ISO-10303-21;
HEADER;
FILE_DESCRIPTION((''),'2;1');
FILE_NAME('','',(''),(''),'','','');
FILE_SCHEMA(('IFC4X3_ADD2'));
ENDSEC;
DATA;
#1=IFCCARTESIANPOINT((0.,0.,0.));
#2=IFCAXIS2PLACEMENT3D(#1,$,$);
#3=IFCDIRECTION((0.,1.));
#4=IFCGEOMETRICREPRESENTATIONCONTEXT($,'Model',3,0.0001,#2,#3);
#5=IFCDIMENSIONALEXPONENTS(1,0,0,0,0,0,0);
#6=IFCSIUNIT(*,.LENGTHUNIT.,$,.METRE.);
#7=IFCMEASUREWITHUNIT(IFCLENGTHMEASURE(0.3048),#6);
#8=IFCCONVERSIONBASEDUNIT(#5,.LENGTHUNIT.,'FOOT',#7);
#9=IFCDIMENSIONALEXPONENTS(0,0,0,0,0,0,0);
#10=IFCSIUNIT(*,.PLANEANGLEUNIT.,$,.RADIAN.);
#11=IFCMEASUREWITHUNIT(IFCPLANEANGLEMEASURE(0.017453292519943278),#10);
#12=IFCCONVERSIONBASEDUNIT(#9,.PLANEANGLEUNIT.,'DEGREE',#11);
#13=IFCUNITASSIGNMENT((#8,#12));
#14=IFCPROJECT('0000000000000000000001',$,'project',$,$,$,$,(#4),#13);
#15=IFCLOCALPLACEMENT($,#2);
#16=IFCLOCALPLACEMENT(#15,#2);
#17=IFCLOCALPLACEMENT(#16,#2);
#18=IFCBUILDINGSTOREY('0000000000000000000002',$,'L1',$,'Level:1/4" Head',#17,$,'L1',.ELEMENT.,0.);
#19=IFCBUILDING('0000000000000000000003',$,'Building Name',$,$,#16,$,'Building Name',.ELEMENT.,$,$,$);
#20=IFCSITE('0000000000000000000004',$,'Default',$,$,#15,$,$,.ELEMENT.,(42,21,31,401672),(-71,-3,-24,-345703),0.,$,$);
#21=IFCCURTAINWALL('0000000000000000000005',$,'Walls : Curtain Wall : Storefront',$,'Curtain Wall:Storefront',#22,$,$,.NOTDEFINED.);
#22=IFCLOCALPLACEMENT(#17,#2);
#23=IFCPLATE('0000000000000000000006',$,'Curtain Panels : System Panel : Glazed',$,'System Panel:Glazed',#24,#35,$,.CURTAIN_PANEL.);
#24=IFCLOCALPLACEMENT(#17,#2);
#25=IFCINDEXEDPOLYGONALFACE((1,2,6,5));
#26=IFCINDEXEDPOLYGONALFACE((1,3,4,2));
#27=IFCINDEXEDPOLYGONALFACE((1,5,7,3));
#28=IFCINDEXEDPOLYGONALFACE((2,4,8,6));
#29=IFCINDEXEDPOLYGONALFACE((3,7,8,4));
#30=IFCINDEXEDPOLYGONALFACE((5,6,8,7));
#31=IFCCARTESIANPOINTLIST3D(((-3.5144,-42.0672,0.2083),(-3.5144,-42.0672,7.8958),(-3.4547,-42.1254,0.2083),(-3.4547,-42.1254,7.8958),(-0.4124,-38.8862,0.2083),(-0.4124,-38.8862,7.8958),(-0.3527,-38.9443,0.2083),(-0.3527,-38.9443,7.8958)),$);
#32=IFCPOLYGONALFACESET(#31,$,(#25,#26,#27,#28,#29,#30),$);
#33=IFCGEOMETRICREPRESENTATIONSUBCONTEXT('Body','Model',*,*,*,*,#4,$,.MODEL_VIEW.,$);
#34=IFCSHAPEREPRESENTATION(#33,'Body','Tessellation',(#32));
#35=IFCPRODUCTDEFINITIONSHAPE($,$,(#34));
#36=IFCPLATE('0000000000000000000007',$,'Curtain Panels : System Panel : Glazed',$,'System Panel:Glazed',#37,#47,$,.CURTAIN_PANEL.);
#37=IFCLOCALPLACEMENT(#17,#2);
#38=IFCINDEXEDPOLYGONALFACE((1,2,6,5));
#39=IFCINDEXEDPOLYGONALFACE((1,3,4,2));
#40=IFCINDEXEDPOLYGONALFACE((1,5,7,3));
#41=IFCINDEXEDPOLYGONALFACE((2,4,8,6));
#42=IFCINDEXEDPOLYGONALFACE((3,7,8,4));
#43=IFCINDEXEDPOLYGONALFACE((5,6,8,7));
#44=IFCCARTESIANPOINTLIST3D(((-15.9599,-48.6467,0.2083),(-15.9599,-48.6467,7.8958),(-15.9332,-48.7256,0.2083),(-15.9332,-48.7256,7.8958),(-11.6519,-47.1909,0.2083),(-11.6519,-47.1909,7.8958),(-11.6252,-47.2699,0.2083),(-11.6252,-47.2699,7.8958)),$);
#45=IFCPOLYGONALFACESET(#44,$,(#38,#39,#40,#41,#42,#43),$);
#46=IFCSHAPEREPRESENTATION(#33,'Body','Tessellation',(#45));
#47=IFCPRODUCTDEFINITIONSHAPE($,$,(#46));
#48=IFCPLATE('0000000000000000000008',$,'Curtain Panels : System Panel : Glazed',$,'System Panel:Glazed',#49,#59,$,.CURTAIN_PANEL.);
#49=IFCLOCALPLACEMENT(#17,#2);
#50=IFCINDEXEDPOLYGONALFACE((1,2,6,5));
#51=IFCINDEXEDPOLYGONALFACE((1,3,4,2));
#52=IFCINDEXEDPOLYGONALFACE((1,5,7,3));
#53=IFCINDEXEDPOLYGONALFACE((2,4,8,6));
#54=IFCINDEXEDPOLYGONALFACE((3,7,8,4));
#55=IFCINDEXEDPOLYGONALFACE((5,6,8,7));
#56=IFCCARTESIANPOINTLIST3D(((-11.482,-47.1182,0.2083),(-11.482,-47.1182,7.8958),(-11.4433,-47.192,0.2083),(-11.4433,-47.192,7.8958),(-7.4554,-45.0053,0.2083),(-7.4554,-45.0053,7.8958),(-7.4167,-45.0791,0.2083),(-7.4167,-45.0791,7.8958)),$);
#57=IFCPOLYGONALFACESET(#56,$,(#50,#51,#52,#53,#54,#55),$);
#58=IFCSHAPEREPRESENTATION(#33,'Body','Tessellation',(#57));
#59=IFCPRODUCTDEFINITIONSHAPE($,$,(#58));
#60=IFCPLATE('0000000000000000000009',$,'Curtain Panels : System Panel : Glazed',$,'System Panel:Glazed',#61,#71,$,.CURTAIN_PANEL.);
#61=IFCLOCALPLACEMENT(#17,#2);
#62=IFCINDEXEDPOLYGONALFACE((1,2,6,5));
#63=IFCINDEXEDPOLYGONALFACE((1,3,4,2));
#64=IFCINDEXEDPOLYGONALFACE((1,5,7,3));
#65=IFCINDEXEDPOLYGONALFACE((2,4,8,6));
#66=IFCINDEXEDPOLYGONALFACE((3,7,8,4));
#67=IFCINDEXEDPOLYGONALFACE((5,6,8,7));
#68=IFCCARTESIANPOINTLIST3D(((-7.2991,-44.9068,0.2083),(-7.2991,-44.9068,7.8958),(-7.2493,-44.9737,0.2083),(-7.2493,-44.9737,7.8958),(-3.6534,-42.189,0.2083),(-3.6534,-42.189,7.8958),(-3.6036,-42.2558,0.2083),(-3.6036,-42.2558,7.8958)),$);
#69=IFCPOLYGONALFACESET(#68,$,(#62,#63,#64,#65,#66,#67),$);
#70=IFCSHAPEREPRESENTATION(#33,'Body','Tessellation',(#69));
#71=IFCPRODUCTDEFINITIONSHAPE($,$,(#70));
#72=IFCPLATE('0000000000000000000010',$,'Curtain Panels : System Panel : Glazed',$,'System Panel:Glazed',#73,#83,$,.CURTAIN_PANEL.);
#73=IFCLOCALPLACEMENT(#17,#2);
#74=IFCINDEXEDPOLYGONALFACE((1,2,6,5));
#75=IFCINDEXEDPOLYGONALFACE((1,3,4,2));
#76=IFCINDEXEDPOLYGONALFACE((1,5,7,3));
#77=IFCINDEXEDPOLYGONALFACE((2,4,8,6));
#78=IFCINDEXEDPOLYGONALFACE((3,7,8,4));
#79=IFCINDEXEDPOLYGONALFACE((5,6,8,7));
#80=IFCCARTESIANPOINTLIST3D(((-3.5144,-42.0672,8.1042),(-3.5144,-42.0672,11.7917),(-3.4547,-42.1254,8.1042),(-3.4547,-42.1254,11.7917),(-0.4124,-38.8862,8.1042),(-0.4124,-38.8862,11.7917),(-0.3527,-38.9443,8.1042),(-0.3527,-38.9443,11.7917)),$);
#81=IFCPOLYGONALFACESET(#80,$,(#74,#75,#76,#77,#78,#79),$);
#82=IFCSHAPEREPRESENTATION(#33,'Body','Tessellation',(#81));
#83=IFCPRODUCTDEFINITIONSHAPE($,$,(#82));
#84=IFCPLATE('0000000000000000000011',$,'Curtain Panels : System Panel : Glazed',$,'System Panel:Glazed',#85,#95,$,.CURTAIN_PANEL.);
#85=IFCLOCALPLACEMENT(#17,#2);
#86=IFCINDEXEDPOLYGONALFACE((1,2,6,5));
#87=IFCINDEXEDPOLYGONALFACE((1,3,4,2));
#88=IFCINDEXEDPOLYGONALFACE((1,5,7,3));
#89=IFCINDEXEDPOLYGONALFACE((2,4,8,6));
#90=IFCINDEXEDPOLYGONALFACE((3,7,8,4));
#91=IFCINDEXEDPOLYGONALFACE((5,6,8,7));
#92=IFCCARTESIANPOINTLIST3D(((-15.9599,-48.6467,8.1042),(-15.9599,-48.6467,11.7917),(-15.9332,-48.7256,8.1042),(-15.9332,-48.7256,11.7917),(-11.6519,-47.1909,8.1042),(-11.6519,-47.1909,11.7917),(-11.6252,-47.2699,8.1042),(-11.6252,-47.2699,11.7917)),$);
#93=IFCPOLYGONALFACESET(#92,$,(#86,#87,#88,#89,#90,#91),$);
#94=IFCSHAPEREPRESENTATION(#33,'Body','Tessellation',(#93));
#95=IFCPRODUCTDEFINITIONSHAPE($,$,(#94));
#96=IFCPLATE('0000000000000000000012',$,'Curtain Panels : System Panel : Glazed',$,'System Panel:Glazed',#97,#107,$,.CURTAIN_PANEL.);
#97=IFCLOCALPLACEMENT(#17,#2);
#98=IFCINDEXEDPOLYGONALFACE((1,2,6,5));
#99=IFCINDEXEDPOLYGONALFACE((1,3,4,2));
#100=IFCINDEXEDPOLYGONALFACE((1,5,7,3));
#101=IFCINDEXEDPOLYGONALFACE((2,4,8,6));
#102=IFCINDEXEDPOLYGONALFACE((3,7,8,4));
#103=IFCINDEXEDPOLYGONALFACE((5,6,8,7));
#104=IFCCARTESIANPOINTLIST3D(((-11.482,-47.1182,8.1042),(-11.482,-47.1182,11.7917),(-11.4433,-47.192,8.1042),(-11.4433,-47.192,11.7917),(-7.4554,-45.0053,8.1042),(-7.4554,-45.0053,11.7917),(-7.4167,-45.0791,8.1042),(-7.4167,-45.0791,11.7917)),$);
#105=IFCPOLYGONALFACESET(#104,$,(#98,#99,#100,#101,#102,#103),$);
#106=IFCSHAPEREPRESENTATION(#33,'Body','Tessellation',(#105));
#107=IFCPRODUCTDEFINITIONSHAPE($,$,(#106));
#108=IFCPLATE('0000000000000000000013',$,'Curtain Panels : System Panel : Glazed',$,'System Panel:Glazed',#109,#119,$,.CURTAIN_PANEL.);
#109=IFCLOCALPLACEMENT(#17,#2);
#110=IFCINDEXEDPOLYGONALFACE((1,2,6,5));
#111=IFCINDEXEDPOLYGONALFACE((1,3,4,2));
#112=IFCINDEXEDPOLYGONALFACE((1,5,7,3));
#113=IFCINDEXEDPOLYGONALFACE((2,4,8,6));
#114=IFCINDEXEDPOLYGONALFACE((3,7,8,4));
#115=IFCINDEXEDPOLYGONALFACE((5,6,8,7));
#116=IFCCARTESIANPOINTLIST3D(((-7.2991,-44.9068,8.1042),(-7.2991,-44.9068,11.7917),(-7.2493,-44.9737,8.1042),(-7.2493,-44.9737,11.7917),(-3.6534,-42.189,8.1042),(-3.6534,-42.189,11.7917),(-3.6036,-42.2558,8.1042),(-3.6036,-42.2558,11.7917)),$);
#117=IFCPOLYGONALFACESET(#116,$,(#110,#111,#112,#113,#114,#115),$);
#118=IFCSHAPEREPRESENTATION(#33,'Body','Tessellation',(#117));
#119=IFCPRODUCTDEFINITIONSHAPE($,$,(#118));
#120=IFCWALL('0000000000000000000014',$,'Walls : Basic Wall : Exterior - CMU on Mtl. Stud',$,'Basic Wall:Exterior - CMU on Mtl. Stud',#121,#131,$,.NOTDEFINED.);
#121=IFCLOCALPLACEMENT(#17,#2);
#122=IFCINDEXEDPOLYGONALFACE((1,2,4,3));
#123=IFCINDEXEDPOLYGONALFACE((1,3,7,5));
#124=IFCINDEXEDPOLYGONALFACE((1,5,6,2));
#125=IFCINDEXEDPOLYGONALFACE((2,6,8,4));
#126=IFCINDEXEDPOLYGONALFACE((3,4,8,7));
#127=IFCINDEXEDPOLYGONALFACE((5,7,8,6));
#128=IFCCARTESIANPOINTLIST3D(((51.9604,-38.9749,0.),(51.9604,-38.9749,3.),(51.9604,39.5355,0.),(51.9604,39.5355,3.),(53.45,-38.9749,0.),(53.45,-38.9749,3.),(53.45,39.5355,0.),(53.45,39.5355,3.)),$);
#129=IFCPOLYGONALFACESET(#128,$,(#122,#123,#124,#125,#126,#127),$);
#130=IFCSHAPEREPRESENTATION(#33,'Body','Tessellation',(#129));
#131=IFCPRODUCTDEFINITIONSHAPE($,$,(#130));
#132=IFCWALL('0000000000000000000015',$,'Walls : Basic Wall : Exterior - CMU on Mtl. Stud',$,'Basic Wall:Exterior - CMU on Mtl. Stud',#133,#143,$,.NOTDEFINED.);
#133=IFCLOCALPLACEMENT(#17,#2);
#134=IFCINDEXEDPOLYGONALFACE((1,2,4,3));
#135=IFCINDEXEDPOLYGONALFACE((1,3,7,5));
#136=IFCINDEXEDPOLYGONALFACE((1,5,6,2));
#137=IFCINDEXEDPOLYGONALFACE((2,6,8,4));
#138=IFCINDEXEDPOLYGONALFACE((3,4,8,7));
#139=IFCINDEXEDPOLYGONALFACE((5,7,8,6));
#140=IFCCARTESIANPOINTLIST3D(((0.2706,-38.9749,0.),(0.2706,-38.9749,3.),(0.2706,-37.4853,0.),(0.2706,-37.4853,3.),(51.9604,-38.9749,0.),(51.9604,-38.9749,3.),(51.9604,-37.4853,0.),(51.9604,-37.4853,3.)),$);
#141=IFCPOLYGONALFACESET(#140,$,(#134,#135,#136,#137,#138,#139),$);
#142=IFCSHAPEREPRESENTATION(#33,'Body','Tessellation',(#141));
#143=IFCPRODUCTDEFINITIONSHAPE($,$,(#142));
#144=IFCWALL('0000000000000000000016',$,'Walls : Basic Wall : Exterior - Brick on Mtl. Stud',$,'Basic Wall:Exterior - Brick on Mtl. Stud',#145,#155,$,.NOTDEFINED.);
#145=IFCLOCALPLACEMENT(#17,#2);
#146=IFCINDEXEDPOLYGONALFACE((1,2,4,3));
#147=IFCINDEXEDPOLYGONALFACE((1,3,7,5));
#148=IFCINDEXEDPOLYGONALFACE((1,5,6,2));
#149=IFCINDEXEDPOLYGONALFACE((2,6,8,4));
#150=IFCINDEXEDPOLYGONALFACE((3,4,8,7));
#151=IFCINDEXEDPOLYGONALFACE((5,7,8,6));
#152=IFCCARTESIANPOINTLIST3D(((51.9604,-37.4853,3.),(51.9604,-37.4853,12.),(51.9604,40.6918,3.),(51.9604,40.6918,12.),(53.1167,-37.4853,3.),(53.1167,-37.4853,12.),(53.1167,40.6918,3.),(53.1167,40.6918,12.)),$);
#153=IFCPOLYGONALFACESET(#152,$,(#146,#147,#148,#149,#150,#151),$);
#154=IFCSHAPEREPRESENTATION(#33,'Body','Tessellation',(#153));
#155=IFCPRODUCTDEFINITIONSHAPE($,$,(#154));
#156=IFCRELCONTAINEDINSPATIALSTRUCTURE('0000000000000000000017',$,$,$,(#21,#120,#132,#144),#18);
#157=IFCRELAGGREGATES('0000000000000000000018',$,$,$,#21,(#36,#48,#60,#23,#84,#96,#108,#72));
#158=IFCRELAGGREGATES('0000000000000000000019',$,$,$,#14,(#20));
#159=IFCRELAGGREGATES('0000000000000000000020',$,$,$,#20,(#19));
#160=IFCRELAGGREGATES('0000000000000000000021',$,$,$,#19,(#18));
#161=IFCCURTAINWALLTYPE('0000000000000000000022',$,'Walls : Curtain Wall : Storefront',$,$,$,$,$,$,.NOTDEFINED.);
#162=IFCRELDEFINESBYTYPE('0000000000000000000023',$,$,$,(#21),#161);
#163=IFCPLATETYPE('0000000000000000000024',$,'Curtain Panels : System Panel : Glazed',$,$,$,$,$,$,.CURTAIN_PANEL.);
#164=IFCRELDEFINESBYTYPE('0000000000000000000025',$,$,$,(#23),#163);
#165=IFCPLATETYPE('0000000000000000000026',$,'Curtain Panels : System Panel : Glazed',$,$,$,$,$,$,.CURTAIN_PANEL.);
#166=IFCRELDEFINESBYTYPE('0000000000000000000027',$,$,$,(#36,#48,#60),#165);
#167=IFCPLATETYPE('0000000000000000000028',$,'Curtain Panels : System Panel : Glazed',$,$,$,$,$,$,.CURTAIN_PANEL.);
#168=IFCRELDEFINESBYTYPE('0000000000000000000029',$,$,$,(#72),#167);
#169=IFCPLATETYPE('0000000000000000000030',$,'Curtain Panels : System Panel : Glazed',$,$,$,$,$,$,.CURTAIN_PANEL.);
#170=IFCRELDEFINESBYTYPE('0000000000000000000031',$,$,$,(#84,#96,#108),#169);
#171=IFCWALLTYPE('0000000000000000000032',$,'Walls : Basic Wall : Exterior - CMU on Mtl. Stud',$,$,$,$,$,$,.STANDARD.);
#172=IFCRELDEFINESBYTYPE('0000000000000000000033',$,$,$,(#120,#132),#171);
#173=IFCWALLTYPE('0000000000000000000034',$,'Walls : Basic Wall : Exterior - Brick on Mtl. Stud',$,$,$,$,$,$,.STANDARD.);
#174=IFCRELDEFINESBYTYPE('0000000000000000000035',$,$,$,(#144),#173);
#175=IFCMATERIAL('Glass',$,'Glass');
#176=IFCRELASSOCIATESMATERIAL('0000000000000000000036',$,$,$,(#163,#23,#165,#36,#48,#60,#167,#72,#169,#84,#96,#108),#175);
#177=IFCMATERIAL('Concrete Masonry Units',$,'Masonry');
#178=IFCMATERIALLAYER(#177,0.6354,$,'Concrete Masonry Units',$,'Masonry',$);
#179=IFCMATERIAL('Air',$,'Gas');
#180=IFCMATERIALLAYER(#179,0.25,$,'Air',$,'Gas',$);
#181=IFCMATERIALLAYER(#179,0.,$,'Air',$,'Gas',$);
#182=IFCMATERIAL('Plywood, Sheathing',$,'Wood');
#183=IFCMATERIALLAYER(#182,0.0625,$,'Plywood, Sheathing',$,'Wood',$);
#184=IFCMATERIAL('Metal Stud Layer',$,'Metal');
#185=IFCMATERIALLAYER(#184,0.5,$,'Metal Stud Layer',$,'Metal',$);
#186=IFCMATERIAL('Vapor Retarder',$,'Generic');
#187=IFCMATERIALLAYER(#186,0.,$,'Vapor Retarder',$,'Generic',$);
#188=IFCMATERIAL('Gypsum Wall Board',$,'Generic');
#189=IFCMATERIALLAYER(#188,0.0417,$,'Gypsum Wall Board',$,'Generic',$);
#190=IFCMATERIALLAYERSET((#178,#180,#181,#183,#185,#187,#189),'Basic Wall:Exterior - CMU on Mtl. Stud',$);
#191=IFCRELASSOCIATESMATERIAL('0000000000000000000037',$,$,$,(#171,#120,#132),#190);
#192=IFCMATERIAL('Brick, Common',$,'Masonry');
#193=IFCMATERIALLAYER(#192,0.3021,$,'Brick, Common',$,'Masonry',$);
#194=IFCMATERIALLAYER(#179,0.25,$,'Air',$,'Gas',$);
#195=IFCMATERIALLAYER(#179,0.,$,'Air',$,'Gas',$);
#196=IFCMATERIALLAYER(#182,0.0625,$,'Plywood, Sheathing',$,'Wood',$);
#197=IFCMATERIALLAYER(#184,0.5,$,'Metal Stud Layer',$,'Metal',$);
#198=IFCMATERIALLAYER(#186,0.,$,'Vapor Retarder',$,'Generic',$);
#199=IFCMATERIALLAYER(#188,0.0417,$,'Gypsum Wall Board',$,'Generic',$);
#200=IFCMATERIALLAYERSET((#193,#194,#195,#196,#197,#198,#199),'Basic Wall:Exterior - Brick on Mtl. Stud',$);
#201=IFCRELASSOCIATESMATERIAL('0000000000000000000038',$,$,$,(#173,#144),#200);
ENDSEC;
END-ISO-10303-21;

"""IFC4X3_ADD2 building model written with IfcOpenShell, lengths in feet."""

from ifc_helpers import new_model, entity, si_unit, converted_unit, direction, frame, frame_2d, origin, place, context, subcontext, project, spatial, rectangle, extrude, source, transform, mapped, material, layer, layer_set, type_object, type_shapes, element, aggregate, save


model = new_model("IFC4X3_ADD2")

# Units and contexts
model_context = context("Model", 3, precision=0.0001, world=origin(), true_north=direction((0.0, 1.0)))
body_context = subcontext(model_context, "Body", "Model", "MODEL_VIEW")
ifc_project = project(units=[converted_unit("LENGTHUNIT", "FOOT", entity("IfcLengthMeasure", 0.3048), si_unit("LENGTHUNIT", "METRE"), dimensions=[1, 0, 0, 0, 0, 0, 0]), converted_unit("PLANEANGLEUNIT", "DEGREE", entity("IfcPlaneAngleMeasure", 0.017453292519943278), si_unit("PLANEANGLEUNIT", "RADIAN"), dimensions=[0, 0, 0, 0, 0, 0, 0])], contexts=[model_context])

# Site, building, storey
site_placement = place(None, origin())
site = spatial("IfcSite", under=ifc_project, at=site_placement, Name="Default", CompositionType="ELEMENT", RefLatitude=(42, 21, 31, 401672), RefLongitude=(-71, -3, -24, -345703), RefElevation=0.0)
building_placement = place(site_placement, origin())
building = spatial("IfcBuilding", under=site, at=building_placement, Name="Building Name", LongName="Building Name", CompositionType="ELEMENT")
storey_placement = place(building_placement, origin())
storey = spatial("IfcBuildingStorey", under=building, at=storey_placement, Name="L1", ObjectType="Level:1/4\" Head", LongName="L1", CompositionType="ELEMENT", Elevation=0.0)

# Curtain wall
curtain_wall_type = type_object("IfcCurtainWallType", Name="Walls : Curtain Wall : Storefront", PredefinedType="NOTDEFINED")
curtain_wall_placement = place(storey_placement, origin())
curtain_wall = element("IfcCurtainWall", 1, at=curtain_wall_placement, inside=storey, type_object=curtain_wall_type, Name="Walls : Curtain Wall : Storefront", ObjectType="Curtain Wall:Storefront", PredefinedType="NOTDEFINED")

# Shared definitions
ifc_material_1 = material(Name="Plywood, Sheathing", Category="Wood")

# Plates
ifc_material_2 = material(Name="Glass", Category="Glass")
plate_type_1 = type_object("IfcPlateType", Name="Curtain Panels : System Panel : Glazed", PredefinedType="CURTAIN_PANEL", material=ifc_material_2)
shared_shape_1 = source(origin(), body_context, "Body", "SweptSolid", [
    extrude(rectangle(XDim=0.0833, YDim=4.4431, at=frame_2d((0.0, 0.0), x_axis=(1.0, 0.0))), frame((2.2216, 0.0417, 0.0), z_axis=(0.0, 0.0, 1.0), x_axis=(0.0, 1.0, 0.0)), (0.0, 0.0, 1.0), 7.6875),
])
type_shapes(plate_type_1, [shared_shape_1])
plate_1_placement = place(curtain_wall_placement, frame((-3.4547, -42.1254, 0.2083), z_axis=(0.0, 0.0, 1.0), x_axis=(0.69815, 0.715952, 0.0)))
plate_1 = element("IfcPlate", 2, at=plate_1_placement, type_object=plate_type_1, material=ifc_material_2, Name="Curtain Panels : System Panel : Glazed", ObjectType="System Panel:Glazed", PredefinedType="CURTAIN_PANEL", context=body_context, shape_type="MappedRepresentation", body=[
    mapped(shared_shape_1, transform((0.0, 0.0, 0.0), scale=1.0)),
])
plate_type_2 = type_object("IfcPlateType", Name="Curtain Panels : System Panel : Glazed", PredefinedType="CURTAIN_PANEL", material=ifc_material_2)
shared_shape_2 = source(origin(), body_context, "Body", "SweptSolid", [
    extrude(rectangle(XDim=0.0833, YDim=4.5473, at=frame_2d((0.0, 0.0), x_axis=(1.0, 0.0))), frame((2.2737, 0.0417, 0.0), z_axis=(0.0, 0.0, 1.0), x_axis=(0.0, 1.0, 0.0)), (0.0, 0.0, 1.0), 7.6875),
])
type_shapes(plate_type_2, [shared_shape_2])
plate_2_placement = place(curtain_wall_placement, frame((-15.9332, -48.7256, 0.2083), z_axis=(0.0, 0.0, 1.0), x_axis=(0.947373, 0.320131, 0.0)))
plate_2 = element("IfcPlate", 3, at=plate_2_placement, type_object=plate_type_2, material=ifc_material_2, Name="Curtain Panels : System Panel : Glazed", ObjectType="System Panel:Glazed", PredefinedType="CURTAIN_PANEL", context=body_context, shape_type="MappedRepresentation", body=[
    mapped(shared_shape_2, transform((0.0, 0.0, 0.0), scale=1.0)),
])
plate_3_placement = place(curtain_wall_placement, frame((-11.4433, -47.192, 0.2083), z_axis=(0.0, 0.0, 1.0), x_axis=(0.885494, 0.464651, 0.0)))
plate_3 = element("IfcPlate", 4, at=plate_3_placement, type_object=plate_type_2, material=ifc_material_2, Name="Curtain Panels : System Panel : Glazed", ObjectType="System Panel:Glazed", PredefinedType="CURTAIN_PANEL", context=body_context, shape_type="MappedRepresentation", body=[
    mapped(shared_shape_2, transform((0.0, 0.0, 0.0), scale=1.0)),
])
plate_4_placement = place(curtain_wall_placement, frame((-7.2493, -44.9737, 0.2083), z_axis=(0.0, 0.0, 1.0), x_axis=(0.801729, 0.597687, 0.0)))
plate_4 = element("IfcPlate", 5, at=plate_4_placement, type_object=plate_type_2, material=ifc_material_2, Name="Curtain Panels : System Panel : Glazed", ObjectType="System Panel:Glazed", PredefinedType="CURTAIN_PANEL", context=body_context, shape_type="MappedRepresentation", body=[
    mapped(shared_shape_2, transform((0.0, 0.0, 0.0), scale=1.0)),
])
plate_type_3 = type_object("IfcPlateType", Name="Curtain Panels : System Panel : Glazed", PredefinedType="CURTAIN_PANEL", material=ifc_material_2)
shared_shape_3 = source(origin(), body_context, "Body", "SweptSolid", [
    extrude(rectangle(XDim=0.0833, YDim=4.4431, at=frame_2d((0.0, 0.0), x_axis=(1.0, 0.0))), frame((2.2216, 0.0417, 0.0), z_axis=(0.0, 0.0, 1.0), x_axis=(0.0, 1.0, 0.0)), (0.0, 0.0, 1.0), 3.6875),
])
type_shapes(plate_type_3, [shared_shape_3])
plate_5_placement = place(curtain_wall_placement, frame((-3.4547, -42.1254, 8.1042), z_axis=(0.0, 0.0, 1.0), x_axis=(0.69815, 0.715952, 0.0)))
plate_5 = element("IfcPlate", 6, at=plate_5_placement, type_object=plate_type_3, material=ifc_material_2, Name="Curtain Panels : System Panel : Glazed", ObjectType="System Panel:Glazed", PredefinedType="CURTAIN_PANEL", context=body_context, shape_type="MappedRepresentation", body=[
    mapped(shared_shape_3, transform((0.0, 0.0, 0.0), scale=1.0)),
])
plate_type_4 = type_object("IfcPlateType", Name="Curtain Panels : System Panel : Glazed", PredefinedType="CURTAIN_PANEL", material=ifc_material_2)
shared_shape_4 = source(origin(), body_context, "Body", "SweptSolid", [
    extrude(rectangle(XDim=0.0833, YDim=4.5473, at=frame_2d((0.0, 0.0), x_axis=(1.0, 0.0))), frame((2.2737, 0.0417, 0.0), z_axis=(0.0, 0.0, 1.0), x_axis=(0.0, 1.0, 0.0)), (0.0, 0.0, 1.0), 3.6875),
])
type_shapes(plate_type_4, [shared_shape_4])
plate_6_placement = place(curtain_wall_placement, frame((-15.9332, -48.7256, 8.1042), z_axis=(0.0, 0.0, 1.0), x_axis=(0.947373, 0.320131, 0.0)))
plate_6 = element("IfcPlate", 7, at=plate_6_placement, type_object=plate_type_4, material=ifc_material_2, Name="Curtain Panels : System Panel : Glazed", ObjectType="System Panel:Glazed", PredefinedType="CURTAIN_PANEL", context=body_context, shape_type="MappedRepresentation", body=[
    mapped(shared_shape_4, transform((0.0, 0.0, 0.0), scale=1.0)),
])
plate_7_placement = place(curtain_wall_placement, frame((-11.4433, -47.192, 8.1042), z_axis=(0.0, 0.0, 1.0), x_axis=(0.885494, 0.464651, 0.0)))
plate_7 = element("IfcPlate", 8, at=plate_7_placement, type_object=plate_type_4, material=ifc_material_2, Name="Curtain Panels : System Panel : Glazed", ObjectType="System Panel:Glazed", PredefinedType="CURTAIN_PANEL", context=body_context, shape_type="MappedRepresentation", body=[
    mapped(shared_shape_4, transform((0.0, 0.0, 0.0), scale=1.0)),
])
plate_8_placement = place(curtain_wall_placement, frame((-7.2493, -44.9737, 8.1042), z_axis=(0.0, 0.0, 1.0), x_axis=(0.801729, 0.597687, 0.0)))
plate_8 = element("IfcPlate", 9, at=plate_8_placement, type_object=plate_type_4, material=ifc_material_2, Name="Curtain Panels : System Panel : Glazed", ObjectType="System Panel:Glazed", PredefinedType="CURTAIN_PANEL", context=body_context, shape_type="MappedRepresentation", body=[
    mapped(shared_shape_4, transform((0.0, 0.0, 0.0), scale=1.0)),
])
aggregate(curtain_wall, [plate_2, plate_3, plate_4, plate_1, plate_6, plate_7, plate_8, plate_5])

# Walls
ifc_material_3 = material(Name="Concrete Masonry Units", Category="Masonry")
ifc_layer_1 = layer(ifc_material_3, 0.6354, Name="Concrete Masonry Units", Category="Masonry")
ifc_material_4 = material(Name="Air", Category="Gas")
ifc_layer_2 = layer(ifc_material_4, 0.25, Name="Air", Category="Gas")
ifc_layer_3 = layer(ifc_material_4, 0.0, Name="Air", Category="Gas")
ifc_layer_4 = layer(ifc_material_1, 0.0625, Name="Plywood, Sheathing", Category="Wood")
ifc_material_5 = material(Name="Metal Stud Layer", Category="Metal")
ifc_layer_5 = layer(ifc_material_5, 0.5, Name="Metal Stud Layer", Category="Metal")
ifc_material_6 = material(Name="Vapor Retarder", Category="Generic")
ifc_layer_6 = layer(ifc_material_6, 0.0, Name="Vapor Retarder", Category="Generic")
ifc_material_7 = material(Name="Gypsum Wall Board", Category="Generic")
ifc_layer_7 = layer(ifc_material_7, 0.0417, Name="Gypsum Wall Board", Category="Generic")
ifc_layer_set_1 = layer_set([ifc_layer_1, ifc_layer_2, ifc_layer_3, ifc_layer_4, ifc_layer_5, ifc_layer_6, ifc_layer_7], Name="Basic Wall:Exterior - CMU on Mtl. Stud")
wall_type_1 = type_object("IfcWallType", Name="Walls : Basic Wall : Exterior - CMU on Mtl. Stud", PredefinedType="STANDARD", material=ifc_layer_set_1)
wall_1_placement = place(storey_placement, frame((52.7052, 39.5355, 0.0), z_axis=(0.0, 0.0, 1.0), x_axis=(0.0, -1.0, 0.0)))
element("IfcWall", 10, at=wall_1_placement, inside=storey, type_object=wall_type_1, material=ifc_layer_set_1, Name="Walls : Basic Wall : Exterior - CMU on Mtl. Stud", ObjectType="Basic Wall:Exterior - CMU on Mtl. Stud", PredefinedType="NOTDEFINED", context=body_context, shape_type="SweptSolid", body=[
    extrude(rectangle(XDim=78.5104, YDim=1.4896, at=frame_2d((39.2552, 0.0), x_axis=(-1.0, 0.0))), origin(), (0.0, 0.0, 1.0), 3.0),
])
wall_2_placement = place(storey_placement, frame((51.9604, -38.2301, 0.0), z_axis=(0.0, 0.0, 1.0), x_axis=(-1.0, 0.0, 0.0)))
element("IfcWall", 11, at=wall_2_placement, inside=storey, type_object=wall_type_1, material=ifc_layer_set_1, Name="Walls : Basic Wall : Exterior - CMU on Mtl. Stud", ObjectType="Basic Wall:Exterior - CMU on Mtl. Stud", PredefinedType="NOTDEFINED", context=body_context, shape_type="SweptSolid", body=[
    extrude(rectangle(XDim=51.6898, YDim=1.4896, at=frame_2d((25.8449, 0.0), x_axis=(-1.0, 0.0))), origin(), (0.0, 0.0, 1.0), 3.0),
])
ifc_material_8 = material(Name="Brick, Common", Category="Masonry")
ifc_layer_8 = layer(ifc_material_8, 0.3021, Name="Brick, Common", Category="Masonry")
ifc_layer_9 = layer(ifc_material_4, 0.25, Name="Air", Category="Gas")
ifc_layer_10 = layer(ifc_material_4, 0.0, Name="Air", Category="Gas")
ifc_layer_11 = layer(ifc_material_1, 0.0625, Name="Plywood, Sheathing", Category="Wood")
ifc_layer_12 = layer(ifc_material_5, 0.5, Name="Metal Stud Layer", Category="Metal")
ifc_layer_13 = layer(ifc_material_6, 0.0, Name="Vapor Retarder", Category="Generic")
ifc_layer_14 = layer(ifc_material_7, 0.0417, Name="Gypsum Wall Board", Category="Generic")
ifc_layer_set_2 = layer_set([ifc_layer_8, ifc_layer_9, ifc_layer_10, ifc_layer_11, ifc_layer_12, ifc_layer_13, ifc_layer_14], Name="Basic Wall:Exterior - Brick on Mtl. Stud")
wall_type_2 = type_object("IfcWallType", Name="Walls : Basic Wall : Exterior - Brick on Mtl. Stud", PredefinedType="STANDARD", material=ifc_layer_set_2)
wall_3_placement = place(storey_placement, frame((52.5386, 40.6918, 3.0), z_axis=(0.0, 0.0, 1.0), x_axis=(0.0, -1.0, 0.0)))
element("IfcWall", 12, at=wall_3_placement, inside=storey, type_object=wall_type_2, material=ifc_layer_set_2, Name="Walls : Basic Wall : Exterior - Brick on Mtl. Stud", ObjectType="Basic Wall:Exterior - Brick on Mtl. Stud", PredefinedType="NOTDEFINED", context=body_context, shape_type="SweptSolid", body=[
    extrude(rectangle(XDim=78.1771, YDim=1.1562, at=frame_2d((39.0885, 0.0), x_axis=(-1.0, 0.0))), origin(), (0.0, 0.0, 1.0), 9.0),
])

save(model, "model.ifc")
